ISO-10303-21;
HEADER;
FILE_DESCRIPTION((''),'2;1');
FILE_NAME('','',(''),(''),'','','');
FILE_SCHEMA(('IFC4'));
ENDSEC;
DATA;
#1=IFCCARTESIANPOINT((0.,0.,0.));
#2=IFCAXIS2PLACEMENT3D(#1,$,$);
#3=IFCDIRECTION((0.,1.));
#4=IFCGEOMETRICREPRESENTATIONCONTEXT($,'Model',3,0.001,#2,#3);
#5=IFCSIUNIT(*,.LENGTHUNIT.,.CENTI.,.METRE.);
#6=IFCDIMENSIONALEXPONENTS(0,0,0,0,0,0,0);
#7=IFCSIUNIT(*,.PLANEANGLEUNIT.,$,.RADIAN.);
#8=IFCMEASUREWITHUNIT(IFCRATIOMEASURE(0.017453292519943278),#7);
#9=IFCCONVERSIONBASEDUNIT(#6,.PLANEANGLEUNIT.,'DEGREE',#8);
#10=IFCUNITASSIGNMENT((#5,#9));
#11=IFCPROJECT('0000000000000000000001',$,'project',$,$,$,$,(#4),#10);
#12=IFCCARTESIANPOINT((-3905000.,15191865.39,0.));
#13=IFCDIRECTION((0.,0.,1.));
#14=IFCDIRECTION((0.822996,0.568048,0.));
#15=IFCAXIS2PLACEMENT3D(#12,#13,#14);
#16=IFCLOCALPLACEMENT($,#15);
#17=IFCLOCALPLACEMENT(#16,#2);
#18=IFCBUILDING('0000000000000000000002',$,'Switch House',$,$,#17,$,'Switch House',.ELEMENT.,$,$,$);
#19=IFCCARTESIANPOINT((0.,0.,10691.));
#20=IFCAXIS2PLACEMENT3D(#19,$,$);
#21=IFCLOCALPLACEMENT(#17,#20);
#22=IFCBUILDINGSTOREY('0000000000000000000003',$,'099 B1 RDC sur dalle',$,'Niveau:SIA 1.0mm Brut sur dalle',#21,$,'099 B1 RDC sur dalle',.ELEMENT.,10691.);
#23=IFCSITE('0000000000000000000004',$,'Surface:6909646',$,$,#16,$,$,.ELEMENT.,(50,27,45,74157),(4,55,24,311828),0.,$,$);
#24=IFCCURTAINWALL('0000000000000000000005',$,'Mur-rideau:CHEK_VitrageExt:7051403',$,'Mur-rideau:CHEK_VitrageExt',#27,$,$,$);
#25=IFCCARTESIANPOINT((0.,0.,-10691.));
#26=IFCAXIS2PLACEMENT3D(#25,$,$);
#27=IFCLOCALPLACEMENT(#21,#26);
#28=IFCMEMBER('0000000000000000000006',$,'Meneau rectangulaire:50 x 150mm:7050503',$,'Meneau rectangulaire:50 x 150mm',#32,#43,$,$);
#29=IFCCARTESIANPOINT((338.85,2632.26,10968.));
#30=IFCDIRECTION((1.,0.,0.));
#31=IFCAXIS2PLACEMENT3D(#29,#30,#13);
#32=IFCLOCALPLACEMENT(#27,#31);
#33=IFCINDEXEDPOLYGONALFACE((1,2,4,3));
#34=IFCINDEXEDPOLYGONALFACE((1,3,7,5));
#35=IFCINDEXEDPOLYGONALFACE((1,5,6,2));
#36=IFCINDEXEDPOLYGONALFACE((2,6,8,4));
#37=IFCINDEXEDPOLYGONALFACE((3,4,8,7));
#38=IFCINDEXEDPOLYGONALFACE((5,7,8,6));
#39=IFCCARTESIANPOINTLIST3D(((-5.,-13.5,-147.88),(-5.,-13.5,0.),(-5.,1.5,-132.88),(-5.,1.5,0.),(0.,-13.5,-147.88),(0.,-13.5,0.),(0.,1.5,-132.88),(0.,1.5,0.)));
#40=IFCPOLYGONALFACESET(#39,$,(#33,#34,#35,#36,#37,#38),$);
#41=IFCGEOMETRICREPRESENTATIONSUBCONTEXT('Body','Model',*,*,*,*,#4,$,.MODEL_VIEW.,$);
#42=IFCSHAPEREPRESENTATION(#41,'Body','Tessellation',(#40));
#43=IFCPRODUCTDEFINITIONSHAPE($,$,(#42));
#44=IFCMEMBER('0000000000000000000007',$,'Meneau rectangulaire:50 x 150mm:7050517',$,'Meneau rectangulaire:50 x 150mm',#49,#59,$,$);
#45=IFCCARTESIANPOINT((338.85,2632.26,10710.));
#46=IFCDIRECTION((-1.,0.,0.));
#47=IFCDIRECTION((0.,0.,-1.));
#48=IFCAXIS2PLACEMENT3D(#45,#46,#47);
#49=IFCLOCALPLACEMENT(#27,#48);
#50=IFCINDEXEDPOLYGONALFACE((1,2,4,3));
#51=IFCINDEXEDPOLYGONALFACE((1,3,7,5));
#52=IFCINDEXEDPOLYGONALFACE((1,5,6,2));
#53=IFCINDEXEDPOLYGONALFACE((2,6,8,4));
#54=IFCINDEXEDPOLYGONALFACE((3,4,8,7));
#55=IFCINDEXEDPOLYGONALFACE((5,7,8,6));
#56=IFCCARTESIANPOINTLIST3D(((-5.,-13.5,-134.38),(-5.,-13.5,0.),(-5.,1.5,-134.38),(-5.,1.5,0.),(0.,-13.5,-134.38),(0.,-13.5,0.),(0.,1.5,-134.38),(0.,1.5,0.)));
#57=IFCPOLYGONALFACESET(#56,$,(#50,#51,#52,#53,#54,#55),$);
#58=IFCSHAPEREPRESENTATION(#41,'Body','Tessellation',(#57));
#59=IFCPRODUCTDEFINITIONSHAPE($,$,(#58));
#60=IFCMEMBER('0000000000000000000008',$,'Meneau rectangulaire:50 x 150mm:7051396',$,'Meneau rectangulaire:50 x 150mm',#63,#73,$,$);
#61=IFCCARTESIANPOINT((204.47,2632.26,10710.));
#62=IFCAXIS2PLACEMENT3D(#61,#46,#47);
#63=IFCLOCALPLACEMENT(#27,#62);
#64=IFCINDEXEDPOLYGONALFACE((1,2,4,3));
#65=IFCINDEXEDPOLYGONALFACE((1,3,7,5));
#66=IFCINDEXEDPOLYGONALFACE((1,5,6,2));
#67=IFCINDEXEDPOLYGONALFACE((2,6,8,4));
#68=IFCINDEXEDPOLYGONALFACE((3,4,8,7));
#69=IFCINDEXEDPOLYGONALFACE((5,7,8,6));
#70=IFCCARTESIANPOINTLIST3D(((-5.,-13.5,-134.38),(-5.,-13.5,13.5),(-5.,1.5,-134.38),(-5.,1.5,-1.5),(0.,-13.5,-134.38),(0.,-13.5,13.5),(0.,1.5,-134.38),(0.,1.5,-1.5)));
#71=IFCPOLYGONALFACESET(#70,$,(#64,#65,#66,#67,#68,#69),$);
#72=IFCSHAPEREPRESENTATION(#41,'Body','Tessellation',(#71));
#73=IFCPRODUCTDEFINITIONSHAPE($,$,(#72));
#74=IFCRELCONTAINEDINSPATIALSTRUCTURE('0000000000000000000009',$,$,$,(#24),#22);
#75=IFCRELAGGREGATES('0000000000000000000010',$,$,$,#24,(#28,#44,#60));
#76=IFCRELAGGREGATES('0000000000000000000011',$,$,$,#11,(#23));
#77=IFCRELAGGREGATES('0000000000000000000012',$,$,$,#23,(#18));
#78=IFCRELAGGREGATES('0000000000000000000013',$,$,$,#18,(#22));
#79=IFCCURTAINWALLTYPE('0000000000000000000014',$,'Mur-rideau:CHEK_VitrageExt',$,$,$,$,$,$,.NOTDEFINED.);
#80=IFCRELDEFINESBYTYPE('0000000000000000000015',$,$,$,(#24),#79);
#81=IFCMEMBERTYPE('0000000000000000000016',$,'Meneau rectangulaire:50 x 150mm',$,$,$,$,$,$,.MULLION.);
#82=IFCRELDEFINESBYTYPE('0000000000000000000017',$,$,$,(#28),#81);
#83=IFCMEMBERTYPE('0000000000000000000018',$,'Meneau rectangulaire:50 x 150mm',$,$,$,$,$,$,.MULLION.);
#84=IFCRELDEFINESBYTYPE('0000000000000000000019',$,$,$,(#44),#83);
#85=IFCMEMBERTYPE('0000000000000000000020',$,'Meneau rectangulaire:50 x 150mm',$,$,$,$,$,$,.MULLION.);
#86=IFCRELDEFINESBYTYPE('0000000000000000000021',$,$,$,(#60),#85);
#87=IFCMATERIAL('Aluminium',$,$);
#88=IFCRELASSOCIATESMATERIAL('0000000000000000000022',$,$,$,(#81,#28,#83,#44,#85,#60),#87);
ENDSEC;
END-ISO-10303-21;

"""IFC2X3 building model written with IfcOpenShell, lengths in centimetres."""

from ifc_helpers import new_model, entity, si_unit, converted_unit, direction, frame, origin, origin_2d_with_axis, place, context, subcontext, project, spatial, rectangle, extrude, clip, halfspace, source, transform, mapped, material, type_object, type_shapes, element, aggregate, save


model = new_model("IFC2X3")

# Units and contexts
model_context = context("Model", 3, precision=0.001, world=origin(), true_north=direction((0.0, 1.0)))
body_context = subcontext(model_context, "Body", "Model", "MODEL_VIEW")
ifc_project = project(units=[si_unit("LENGTHUNIT", "METRE", prefix="CENTI"), converted_unit("PLANEANGLEUNIT", "DEGREE", entity("IfcRatioMeasure", 0.017453292519943278), si_unit("PLANEANGLEUNIT", "RADIAN"), dimensions=[0, 0, 0, 0, 0, 0, 0])], contexts=[model_context])

# Site, building, storey
site_placement = place(None, frame((-3905000.0, 15191865.39, 0.0), z_axis=(0.0, 0.0, 1.0), x_axis=(0.822996, 0.568048, 0.0)))
site = spatial("IfcSite", under=ifc_project, at=site_placement, Name="Surface:6909646", CompositionType="ELEMENT", RefLatitude=(50, 27, 45, 74157), RefLongitude=(4, 55, 24, 311828), RefElevation=0.0)
building_placement = place(site_placement, origin())
building = spatial("IfcBuilding", under=site, at=building_placement, Name="Switch House", LongName="Switch House", CompositionType="ELEMENT")
storey_placement = place(building_placement, frame((0.0, 0.0, 10691.0)))
storey = spatial("IfcBuildingStorey", under=building, at=storey_placement, Name="099 B1 RDC sur dalle", ObjectType="Niveau:SIA 1.0mm Brut sur dalle", LongName="099 B1 RDC sur dalle", CompositionType="ELEMENT", Elevation=10691.0)

# Curtain wall
curtain_wall_type = type_object("IfcCurtainWallType", Name="Mur-rideau:CHEK_VitrageExt", PredefinedType="NOTDEFINED")
ifc_material_1 = material(Name="Aluminium")
curtain_wall_1_placement = place(storey_placement, frame((0.0, 0.0, -10691.0)))
curtain_wall_1 = element("IfcCurtainWall", 1, at=curtain_wall_1_placement, inside=storey, type_object=curtain_wall_type, Name="Mur-rideau:CHEK_VitrageExt:7051403", ObjectType="Mur-rideau:CHEK_VitrageExt")

# Members
member_type_1 = type_object("IfcMemberType", Name="Meneau rectangulaire:50 x 150mm", PredefinedType="MULLION", material=ifc_material_1)
shared_shape_1 = source(origin(), body_context, "Body", "SweptSolid", [
    clip(extrude(rectangle(XDim=15.0, YDim=5.0, at=origin_2d_with_axis()), frame((-2.5, -6.0, -147.88), z_axis=(0.0, 0.0, 1.0), x_axis=(0.0, -1.0, 0.0)), (0.0, 0.0, 1.0), 147.88), halfspace(frame((-30.48, 0.0, -134.38), z_axis=(0.0, 0.707107, -0.707107), x_axis=(0.0, 0.707107, 0.707107)), False)),
])
type_shapes(member_type_1, [shared_shape_1])
member_1_placement = place(curtain_wall_1_placement, frame((338.85, 2632.26, 10968.0), z_axis=(1.0, 0.0, 0.0), x_axis=(0.0, 0.0, 1.0)))
member_1 = element("IfcMember", 2, at=member_1_placement, type_object=member_type_1, material=ifc_material_1, Name="Meneau rectangulaire:50 x 150mm:7050503", ObjectType="Meneau rectangulaire:50 x 150mm", context=body_context, shape_type="MappedRepresentation", body=[
    mapped(shared_shape_1, transform((0.0, 0.0, 0.0), scale=1.0)),
])
member_type_2 = type_object("IfcMemberType", Name="Meneau rectangulaire:50 x 150mm", PredefinedType="MULLION", material=ifc_material_1)
shared_shape_2 = source(origin(), body_context, "Body", "SweptSolid", [
    extrude(rectangle(XDim=15.0, YDim=5.0, at=origin_2d_with_axis()), frame((-2.5, -6.0, -134.38), z_axis=(0.0, 0.0, 1.0), x_axis=(0.0, -1.0, 0.0)), (0.0, 0.0, 1.0), 134.38),
])
type_shapes(member_type_2, [shared_shape_2])
member_2_placement = place(curtain_wall_1_placement, frame((338.85, 2632.26, 10710.0), z_axis=(-1.0, 0.0, 0.0), x_axis=(0.0, 0.0, -1.0)))
member_2 = element("IfcMember", 3, at=member_2_placement, type_object=member_type_2, material=ifc_material_1, Name="Meneau rectangulaire:50 x 150mm:7050517", ObjectType="Meneau rectangulaire:50 x 150mm", context=body_context, shape_type="MappedRepresentation", body=[
    mapped(shared_shape_2, transform((0.0, 0.0, 0.0), scale=1.0)),
])
member_type_3 = type_object("IfcMemberType", Name="Meneau rectangulaire:50 x 150mm", PredefinedType="MULLION", material=ifc_material_1)
shared_shape_3 = source(origin(), body_context, "Body", "SweptSolid", [
    clip(extrude(rectangle(XDim=15.0, YDim=5.0, at=origin_2d_with_axis()), frame((-2.5, -6.0, -134.38), z_axis=(0.0, 0.0, 1.0), x_axis=(0.0, -1.0, 0.0)), (0.0, 0.0, 1.0), 147.88), halfspace(frame((-30.48, 0.0, 0.0), z_axis=(0.0, 0.707107, 0.707107), x_axis=(0.0, 0.707107, -0.707107)), False)),
])
type_shapes(member_type_3, [shared_shape_3])
member_3_placement = place(curtain_wall_1_placement, frame((204.47, 2632.26, 10710.0), z_axis=(-1.0, 0.0, 0.0), x_axis=(0.0, 0.0, -1.0)))
member_3 = element("IfcMember", 4, at=member_3_placement, type_object=member_type_3, material=ifc_material_1, Name="Meneau rectangulaire:50 x 150mm:7051396", ObjectType="Meneau rectangulaire:50 x 150mm", context=body_context, shape_type="MappedRepresentation", body=[
    mapped(shared_shape_3, transform((0.0, 0.0, 0.0), scale=1.0)),
])

aggregate(curtain_wall_1, [member_1, member_2, member_3])

save(model, "model.ifc")
